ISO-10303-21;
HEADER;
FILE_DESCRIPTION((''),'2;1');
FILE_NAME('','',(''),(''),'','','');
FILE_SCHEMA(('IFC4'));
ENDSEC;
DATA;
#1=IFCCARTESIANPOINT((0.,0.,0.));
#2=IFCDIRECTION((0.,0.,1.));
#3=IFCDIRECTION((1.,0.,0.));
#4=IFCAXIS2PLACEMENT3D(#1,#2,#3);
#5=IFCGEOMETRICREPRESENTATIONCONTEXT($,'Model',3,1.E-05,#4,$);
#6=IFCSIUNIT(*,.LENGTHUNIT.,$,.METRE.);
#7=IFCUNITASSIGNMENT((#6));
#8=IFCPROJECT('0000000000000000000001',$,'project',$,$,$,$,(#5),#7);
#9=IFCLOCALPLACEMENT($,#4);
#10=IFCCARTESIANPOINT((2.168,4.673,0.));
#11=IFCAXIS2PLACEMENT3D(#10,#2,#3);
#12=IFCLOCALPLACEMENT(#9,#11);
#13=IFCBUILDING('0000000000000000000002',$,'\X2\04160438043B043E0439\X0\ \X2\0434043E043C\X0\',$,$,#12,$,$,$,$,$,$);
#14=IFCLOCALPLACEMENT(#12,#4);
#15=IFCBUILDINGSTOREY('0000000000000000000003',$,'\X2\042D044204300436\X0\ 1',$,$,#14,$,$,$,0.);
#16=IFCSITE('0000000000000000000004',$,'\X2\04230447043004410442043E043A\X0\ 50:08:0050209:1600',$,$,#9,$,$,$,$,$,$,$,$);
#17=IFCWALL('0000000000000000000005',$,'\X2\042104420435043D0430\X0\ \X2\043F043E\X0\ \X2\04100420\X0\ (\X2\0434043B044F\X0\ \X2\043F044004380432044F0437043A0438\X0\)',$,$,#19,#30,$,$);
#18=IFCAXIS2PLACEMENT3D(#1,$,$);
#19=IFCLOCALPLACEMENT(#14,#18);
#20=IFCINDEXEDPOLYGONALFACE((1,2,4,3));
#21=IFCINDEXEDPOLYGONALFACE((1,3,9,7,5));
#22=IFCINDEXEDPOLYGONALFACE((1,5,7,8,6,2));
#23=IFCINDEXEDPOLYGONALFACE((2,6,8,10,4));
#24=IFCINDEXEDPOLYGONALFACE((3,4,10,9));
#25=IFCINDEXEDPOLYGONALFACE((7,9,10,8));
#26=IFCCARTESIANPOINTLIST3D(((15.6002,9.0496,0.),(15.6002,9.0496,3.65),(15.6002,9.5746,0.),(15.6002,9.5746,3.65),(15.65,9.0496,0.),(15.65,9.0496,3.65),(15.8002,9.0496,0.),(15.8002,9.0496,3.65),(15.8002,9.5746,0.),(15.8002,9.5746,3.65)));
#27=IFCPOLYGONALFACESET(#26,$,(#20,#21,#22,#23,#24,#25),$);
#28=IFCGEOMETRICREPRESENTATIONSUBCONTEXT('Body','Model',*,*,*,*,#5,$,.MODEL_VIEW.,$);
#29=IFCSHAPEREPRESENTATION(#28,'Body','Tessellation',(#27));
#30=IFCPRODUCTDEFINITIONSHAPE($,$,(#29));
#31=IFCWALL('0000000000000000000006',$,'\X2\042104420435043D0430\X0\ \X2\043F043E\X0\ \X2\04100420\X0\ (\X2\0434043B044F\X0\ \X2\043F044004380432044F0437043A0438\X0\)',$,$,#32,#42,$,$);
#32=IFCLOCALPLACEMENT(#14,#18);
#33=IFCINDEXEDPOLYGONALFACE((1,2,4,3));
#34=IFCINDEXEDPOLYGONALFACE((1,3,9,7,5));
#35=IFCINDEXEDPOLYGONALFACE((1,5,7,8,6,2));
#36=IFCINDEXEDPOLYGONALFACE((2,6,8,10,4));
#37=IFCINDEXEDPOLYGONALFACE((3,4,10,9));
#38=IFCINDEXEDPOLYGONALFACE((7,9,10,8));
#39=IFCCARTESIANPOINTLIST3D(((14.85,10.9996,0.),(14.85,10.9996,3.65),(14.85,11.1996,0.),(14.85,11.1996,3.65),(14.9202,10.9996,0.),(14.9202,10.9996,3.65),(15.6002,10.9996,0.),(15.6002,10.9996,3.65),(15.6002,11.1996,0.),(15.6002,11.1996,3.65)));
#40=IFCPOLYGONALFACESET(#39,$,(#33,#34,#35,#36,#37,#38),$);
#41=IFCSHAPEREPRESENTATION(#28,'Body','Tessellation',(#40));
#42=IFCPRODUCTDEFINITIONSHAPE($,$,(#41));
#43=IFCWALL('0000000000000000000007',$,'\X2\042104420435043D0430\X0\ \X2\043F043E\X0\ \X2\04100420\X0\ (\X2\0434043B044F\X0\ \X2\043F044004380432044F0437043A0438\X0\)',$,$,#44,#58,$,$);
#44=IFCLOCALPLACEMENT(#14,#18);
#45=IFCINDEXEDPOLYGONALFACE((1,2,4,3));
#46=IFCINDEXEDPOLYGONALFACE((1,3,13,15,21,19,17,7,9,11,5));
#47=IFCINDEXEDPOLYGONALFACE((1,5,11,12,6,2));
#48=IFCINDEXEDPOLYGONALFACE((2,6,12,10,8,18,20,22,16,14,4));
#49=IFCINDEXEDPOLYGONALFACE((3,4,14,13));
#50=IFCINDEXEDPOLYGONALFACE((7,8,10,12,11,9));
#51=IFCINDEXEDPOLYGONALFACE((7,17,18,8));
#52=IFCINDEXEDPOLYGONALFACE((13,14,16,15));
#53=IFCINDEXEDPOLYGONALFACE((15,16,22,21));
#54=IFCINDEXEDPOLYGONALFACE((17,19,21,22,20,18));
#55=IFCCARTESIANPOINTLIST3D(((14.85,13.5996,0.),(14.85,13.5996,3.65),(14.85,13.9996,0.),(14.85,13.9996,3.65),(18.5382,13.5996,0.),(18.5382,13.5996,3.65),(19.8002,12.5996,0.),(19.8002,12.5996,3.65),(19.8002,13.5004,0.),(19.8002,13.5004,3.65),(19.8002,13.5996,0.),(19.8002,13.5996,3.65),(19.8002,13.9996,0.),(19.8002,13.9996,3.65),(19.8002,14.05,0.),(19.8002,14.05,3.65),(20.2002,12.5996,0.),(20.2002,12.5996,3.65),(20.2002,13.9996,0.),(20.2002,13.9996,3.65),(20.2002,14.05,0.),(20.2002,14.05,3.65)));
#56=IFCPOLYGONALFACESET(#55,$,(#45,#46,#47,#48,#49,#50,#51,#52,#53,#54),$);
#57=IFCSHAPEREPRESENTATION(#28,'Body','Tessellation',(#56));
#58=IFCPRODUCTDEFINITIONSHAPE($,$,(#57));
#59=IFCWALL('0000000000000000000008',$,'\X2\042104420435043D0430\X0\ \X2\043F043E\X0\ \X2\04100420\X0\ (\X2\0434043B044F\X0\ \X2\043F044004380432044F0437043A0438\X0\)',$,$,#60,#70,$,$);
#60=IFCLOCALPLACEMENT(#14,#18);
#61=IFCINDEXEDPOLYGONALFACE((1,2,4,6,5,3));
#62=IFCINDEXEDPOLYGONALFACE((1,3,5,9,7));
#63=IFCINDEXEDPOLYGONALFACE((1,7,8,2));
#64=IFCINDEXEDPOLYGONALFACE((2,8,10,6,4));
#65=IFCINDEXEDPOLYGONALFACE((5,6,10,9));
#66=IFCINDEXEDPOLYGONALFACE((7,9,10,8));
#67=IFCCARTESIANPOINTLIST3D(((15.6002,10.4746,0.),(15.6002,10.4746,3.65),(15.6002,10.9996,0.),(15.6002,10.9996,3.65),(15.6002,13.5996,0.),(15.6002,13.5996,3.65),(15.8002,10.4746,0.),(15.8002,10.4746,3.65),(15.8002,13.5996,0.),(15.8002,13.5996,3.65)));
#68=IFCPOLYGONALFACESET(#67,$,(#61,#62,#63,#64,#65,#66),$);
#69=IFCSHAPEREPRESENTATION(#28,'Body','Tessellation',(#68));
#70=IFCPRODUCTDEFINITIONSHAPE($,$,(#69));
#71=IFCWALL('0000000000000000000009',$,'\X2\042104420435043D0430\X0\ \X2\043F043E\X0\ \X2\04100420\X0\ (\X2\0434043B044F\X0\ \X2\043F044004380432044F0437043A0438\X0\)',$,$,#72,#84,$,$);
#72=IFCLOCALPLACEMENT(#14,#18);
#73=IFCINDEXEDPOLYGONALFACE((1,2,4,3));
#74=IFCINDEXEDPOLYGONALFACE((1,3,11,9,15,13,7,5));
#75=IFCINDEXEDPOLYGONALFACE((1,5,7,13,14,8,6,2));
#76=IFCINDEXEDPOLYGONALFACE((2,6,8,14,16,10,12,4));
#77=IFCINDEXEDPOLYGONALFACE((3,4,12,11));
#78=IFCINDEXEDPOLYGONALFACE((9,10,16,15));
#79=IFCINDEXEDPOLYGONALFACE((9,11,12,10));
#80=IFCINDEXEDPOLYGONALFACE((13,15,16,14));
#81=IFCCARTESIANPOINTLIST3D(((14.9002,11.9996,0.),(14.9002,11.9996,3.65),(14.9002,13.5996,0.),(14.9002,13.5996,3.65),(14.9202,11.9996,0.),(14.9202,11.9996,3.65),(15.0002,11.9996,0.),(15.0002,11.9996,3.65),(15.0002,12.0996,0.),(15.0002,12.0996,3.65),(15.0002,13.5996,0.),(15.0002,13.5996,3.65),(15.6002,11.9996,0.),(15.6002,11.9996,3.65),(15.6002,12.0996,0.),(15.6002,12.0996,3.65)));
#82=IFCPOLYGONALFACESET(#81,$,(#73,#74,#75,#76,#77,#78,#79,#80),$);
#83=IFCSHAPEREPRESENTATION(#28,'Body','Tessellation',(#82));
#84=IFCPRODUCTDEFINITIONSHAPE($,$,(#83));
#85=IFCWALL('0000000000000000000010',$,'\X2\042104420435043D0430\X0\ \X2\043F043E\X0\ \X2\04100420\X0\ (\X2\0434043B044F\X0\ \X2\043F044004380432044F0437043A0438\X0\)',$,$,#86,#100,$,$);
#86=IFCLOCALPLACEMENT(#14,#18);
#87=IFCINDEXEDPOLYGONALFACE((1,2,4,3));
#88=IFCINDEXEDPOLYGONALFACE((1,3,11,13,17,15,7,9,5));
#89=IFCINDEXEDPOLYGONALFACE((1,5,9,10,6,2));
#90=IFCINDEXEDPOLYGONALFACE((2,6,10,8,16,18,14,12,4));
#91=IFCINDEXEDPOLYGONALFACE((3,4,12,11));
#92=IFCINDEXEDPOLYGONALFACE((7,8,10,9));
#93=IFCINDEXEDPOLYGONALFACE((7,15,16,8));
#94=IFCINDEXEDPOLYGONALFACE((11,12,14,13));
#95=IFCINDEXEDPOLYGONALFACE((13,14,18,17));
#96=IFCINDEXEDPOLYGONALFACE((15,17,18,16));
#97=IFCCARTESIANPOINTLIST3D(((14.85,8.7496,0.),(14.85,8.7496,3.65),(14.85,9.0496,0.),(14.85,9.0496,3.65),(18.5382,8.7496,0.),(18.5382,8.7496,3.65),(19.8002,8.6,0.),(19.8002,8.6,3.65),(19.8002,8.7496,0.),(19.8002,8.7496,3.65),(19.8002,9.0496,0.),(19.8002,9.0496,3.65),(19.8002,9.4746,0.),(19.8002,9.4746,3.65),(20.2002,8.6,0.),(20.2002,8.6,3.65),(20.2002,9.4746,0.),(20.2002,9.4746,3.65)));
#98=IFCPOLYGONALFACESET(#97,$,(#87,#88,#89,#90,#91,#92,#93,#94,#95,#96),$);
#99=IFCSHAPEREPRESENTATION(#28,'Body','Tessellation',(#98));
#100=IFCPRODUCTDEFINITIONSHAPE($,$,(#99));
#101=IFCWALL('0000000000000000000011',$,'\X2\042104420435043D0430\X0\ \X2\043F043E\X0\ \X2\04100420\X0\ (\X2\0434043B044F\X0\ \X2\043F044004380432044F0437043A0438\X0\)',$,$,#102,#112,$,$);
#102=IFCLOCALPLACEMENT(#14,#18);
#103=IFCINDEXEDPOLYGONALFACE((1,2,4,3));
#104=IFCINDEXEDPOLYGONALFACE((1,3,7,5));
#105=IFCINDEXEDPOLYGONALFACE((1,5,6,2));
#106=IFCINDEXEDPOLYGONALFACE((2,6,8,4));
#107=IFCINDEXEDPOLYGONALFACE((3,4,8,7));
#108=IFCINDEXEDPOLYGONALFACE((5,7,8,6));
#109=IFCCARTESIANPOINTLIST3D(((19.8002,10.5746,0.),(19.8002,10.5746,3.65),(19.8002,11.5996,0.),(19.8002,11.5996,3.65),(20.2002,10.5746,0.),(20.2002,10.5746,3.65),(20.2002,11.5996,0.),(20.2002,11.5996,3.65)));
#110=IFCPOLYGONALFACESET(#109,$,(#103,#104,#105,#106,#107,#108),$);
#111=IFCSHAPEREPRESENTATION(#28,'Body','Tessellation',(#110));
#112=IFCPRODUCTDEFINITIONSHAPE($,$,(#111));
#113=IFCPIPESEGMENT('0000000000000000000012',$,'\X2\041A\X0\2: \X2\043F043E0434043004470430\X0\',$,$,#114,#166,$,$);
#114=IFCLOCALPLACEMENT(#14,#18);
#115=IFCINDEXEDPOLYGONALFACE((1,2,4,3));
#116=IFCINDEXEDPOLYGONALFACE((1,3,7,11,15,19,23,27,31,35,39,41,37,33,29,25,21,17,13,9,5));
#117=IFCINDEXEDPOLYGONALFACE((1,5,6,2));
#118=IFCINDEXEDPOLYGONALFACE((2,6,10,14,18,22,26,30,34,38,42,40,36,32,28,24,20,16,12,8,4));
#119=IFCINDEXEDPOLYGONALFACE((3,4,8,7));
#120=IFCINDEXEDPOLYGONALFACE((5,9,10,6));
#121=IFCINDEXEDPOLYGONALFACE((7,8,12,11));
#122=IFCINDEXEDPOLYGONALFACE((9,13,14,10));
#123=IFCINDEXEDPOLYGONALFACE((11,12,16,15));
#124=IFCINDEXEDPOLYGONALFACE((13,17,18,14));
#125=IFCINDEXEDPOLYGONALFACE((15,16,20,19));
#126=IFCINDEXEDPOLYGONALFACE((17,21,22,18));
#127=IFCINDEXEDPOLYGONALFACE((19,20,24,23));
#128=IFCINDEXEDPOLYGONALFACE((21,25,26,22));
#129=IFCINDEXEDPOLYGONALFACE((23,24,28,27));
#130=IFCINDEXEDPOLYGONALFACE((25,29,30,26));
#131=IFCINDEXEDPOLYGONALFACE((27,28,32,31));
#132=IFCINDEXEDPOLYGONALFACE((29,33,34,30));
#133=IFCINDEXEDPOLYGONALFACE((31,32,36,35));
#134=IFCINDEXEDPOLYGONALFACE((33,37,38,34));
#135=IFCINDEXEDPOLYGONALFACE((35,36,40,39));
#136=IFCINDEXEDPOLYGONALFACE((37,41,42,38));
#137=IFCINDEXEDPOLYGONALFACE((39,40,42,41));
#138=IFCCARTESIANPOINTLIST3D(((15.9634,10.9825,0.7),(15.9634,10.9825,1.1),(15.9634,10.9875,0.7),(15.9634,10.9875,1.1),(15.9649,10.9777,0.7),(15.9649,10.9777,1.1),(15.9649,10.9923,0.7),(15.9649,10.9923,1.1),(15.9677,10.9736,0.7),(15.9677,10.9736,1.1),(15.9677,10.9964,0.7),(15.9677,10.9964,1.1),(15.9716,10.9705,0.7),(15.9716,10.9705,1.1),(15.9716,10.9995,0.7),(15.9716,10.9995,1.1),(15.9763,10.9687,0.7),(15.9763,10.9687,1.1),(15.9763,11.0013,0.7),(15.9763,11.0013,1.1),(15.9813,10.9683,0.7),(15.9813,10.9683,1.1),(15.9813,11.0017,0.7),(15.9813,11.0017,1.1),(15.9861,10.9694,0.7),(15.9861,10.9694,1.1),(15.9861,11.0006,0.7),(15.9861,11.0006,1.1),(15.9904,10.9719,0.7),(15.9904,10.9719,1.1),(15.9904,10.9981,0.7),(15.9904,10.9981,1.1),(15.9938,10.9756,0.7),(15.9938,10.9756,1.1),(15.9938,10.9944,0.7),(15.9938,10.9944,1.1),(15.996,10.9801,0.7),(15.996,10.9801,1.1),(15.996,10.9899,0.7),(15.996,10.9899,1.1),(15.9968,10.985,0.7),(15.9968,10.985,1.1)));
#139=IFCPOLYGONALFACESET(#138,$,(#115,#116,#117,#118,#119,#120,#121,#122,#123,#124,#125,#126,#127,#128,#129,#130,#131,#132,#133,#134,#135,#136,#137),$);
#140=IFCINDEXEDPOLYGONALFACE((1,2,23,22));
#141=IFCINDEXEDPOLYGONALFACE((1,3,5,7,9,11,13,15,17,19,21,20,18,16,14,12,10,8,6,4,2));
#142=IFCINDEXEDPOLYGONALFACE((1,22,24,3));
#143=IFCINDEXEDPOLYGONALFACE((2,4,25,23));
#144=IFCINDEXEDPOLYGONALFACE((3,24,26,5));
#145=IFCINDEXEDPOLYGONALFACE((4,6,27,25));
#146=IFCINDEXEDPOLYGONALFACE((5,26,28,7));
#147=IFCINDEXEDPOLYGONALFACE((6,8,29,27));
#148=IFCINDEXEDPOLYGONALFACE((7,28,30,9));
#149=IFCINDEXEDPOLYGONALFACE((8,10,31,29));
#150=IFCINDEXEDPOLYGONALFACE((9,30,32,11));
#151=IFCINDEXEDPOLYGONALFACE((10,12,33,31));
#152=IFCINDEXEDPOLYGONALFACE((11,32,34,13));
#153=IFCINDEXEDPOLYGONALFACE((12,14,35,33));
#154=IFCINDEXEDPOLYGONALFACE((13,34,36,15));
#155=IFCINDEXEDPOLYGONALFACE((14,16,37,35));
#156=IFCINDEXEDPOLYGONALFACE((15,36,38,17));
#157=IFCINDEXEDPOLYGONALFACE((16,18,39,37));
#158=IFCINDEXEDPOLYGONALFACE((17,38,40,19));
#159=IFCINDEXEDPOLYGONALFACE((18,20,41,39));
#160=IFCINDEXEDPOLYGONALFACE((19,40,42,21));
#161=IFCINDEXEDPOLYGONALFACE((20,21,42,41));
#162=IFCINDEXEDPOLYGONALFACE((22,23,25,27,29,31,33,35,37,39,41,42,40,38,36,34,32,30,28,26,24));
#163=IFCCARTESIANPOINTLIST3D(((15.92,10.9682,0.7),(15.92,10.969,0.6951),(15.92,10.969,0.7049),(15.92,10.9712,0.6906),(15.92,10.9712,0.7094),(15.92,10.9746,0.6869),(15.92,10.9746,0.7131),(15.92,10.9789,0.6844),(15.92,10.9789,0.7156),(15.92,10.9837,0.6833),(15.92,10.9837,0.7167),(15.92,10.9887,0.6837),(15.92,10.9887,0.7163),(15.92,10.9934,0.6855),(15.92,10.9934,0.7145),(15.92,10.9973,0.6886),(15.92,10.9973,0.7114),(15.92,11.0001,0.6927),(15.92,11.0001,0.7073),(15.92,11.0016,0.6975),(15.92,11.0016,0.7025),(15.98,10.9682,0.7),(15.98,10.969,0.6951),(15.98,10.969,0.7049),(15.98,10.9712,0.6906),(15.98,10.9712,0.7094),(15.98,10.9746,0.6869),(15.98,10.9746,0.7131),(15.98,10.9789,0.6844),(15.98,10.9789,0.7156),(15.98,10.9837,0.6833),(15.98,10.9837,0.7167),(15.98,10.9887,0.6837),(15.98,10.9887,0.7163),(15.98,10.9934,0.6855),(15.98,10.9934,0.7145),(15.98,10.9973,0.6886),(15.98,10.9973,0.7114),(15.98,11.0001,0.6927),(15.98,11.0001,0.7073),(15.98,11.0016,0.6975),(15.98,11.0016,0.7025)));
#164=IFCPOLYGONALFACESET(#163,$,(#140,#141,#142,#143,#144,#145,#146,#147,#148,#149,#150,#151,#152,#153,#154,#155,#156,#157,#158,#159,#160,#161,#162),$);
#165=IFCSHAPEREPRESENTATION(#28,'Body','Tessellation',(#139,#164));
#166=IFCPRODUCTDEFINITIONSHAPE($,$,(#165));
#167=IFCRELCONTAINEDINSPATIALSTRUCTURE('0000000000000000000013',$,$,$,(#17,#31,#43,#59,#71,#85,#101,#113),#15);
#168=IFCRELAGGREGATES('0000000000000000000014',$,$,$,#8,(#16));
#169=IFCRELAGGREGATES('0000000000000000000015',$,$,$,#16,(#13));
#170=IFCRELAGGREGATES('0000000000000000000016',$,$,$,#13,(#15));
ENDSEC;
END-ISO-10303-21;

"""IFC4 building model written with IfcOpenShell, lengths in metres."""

from ifc_helpers import new_model, si_unit, frame, origin_with_axes, origin_2d, place, context, subcontext, project, spatial, polyline, circle, outline, extrude, element, save


model = new_model("IFC4")

# Units and contexts
model_context = context("Model", 3, precision=1e-05, world=origin_with_axes())
body_context = subcontext(model_context, "Body", "Model", "MODEL_VIEW")
ifc_project = project(units=[si_unit("LENGTHUNIT", "METRE")], contexts=[model_context])

# Site, building, storey
site_placement = place(None, origin_with_axes())
site = spatial("IfcSite", under=ifc_project, at=site_placement, Name="Участок 50:08:0050209:1600")
building_placement = place(site_placement, frame((2.168, 4.673, 0.0), z_axis=(0.0, 0.0, 1.0), x_axis=(1.0, 0.0, 0.0)))
building = spatial("IfcBuilding", under=site, at=building_placement, Name="Жилой дом")
storey_placement = place(building_placement, origin_with_axes())
storey = spatial("IfcBuildingStorey", under=building, at=storey_placement, Name="Этаж 1", Elevation=0.0)

# Walls
wall_1_placement = place(storey_placement, origin_with_axes())
element("IfcWall", 1, at=wall_1_placement, inside=storey, Name="Стена по АР (для привязки)", context=body_context, shape_type="SweptSolid", body=[
    extrude(outline(polyline([(15.6002, 9.5746), (15.8002, 9.5746), (15.8002, 9.0496), (15.65, 9.0496), (15.6002, 9.0496), (15.6002, 9.5746)])), origin_with_axes(), (0.0, 0.0, 1.0), 3.65),
])
wall_2_placement = place(storey_placement, origin_with_axes())
element("IfcWall", 2, at=wall_2_placement, inside=storey, Name="Стена по АР (для привязки)", context=body_context, shape_type="SweptSolid", body=[
    extrude(outline(polyline([(14.85, 10.9996), (14.85, 11.1996), (15.6002, 11.1996), (15.6002, 10.9996), (14.9202, 10.9996), (14.85, 10.9996)])), origin_with_axes(), (0.0, 0.0, 1.0), 3.65),
])
wall_3_placement = place(storey_placement, origin_with_axes())
element("IfcWall", 3, at=wall_3_placement, inside=storey, Name="Стена по АР (для привязки)", context=body_context, shape_type="SweptSolid", body=[
    extrude(outline(polyline([(19.8002, 13.9996), (19.8002, 14.05), (20.2002, 14.05), (20.2002, 13.9996), (20.2002, 12.5996), (19.8002, 12.5996), (19.8002, 13.5004), (19.8002, 13.5996), (18.5382, 13.5996), (14.85, 13.5996), (14.85, 13.9996), (19.8002, 13.9996)])), origin_with_axes(), (0.0, 0.0, 1.0), 3.65),
])
wall_4_placement = place(storey_placement, origin_with_axes())
element("IfcWall", 4, at=wall_4_placement, inside=storey, Name="Стена по АР (для привязки)", context=body_context, shape_type="SweptSolid", body=[
    extrude(outline(polyline([(15.8002, 13.5996), (15.8002, 10.4746), (15.6002, 10.4746), (15.6002, 10.9996), (15.6002, 13.5996), (15.8002, 13.5996)])), origin_with_axes(), (0.0, 0.0, 1.0), 3.65),
])
wall_5_placement = place(storey_placement, origin_with_axes())
element("IfcWall", 5, at=wall_5_placement, inside=storey, Name="Стена по АР (для привязки)", context=body_context, shape_type="SweptSolid", body=[
    extrude(outline(polyline([(15.0002, 13.5996), (15.0002, 12.0996), (15.6002, 12.0996), (15.6002, 11.9996), (15.0002, 11.9996), (14.9202, 11.9996), (14.9002, 11.9996), (14.9002, 13.5996), (15.0002, 13.5996)])), origin_with_axes(), (0.0, 0.0, 1.0), 3.65),
])
wall_6_placement = place(storey_placement, origin_with_axes())
element("IfcWall", 6, at=wall_6_placement, inside=storey, Name="Стена по АР (для привязки)", context=body_context, shape_type="SweptSolid", body=[
    extrude(outline(polyline([(19.8002, 8.7496), (18.5382, 8.7496), (14.85, 8.7496), (14.85, 9.0496), (19.8002, 9.0496), (19.8002, 9.4746), (20.2002, 9.4746), (20.2002, 8.6), (19.8002, 8.6), (19.8002, 8.7496)])), origin_with_axes(), (0.0, 0.0, 1.0), 3.65),
])
wall_7_placement = place(storey_placement, origin_with_axes())
element("IfcWall", 7, at=wall_7_placement, inside=storey, Name="Стена по АР (для привязки)", context=body_context, shape_type="SweptSolid", body=[
    extrude(outline(polyline([(20.2002, 10.5746), (19.8002, 10.5746), (19.8002, 11.5996), (20.2002, 11.5996), (20.2002, 10.5746)])), origin_with_axes(), (0.0, 0.0, 1.0), 3.65),
])

# Pipe segment
pipe_segment_1_placement = place(storey_placement, origin_with_axes())
element("IfcPipeSegment", 8, at=pipe_segment_1_placement, inside=storey, Name="К2: подача", context=body_context, shape_type="SweptSolid", body=[
    extrude(circle(Radius=0.0168, at=origin_2d()), frame((15.98, 10.985, 1.1), z_axis=(0.0, 0.0, -1.0), x_axis=(1.0, 0.0, 0.0)), (0.0, 0.0, 1.0), 0.4),
    extrude(circle(Radius=0.0168, at=origin_2d()), frame((15.98, 10.985, 0.7), z_axis=(-1.0, 0.0, 0.0), x_axis=(0.0, -1.0, 0.0)), (0.0, 0.0, 1.0), 0.06),
])

save(model, "model.ifc")
